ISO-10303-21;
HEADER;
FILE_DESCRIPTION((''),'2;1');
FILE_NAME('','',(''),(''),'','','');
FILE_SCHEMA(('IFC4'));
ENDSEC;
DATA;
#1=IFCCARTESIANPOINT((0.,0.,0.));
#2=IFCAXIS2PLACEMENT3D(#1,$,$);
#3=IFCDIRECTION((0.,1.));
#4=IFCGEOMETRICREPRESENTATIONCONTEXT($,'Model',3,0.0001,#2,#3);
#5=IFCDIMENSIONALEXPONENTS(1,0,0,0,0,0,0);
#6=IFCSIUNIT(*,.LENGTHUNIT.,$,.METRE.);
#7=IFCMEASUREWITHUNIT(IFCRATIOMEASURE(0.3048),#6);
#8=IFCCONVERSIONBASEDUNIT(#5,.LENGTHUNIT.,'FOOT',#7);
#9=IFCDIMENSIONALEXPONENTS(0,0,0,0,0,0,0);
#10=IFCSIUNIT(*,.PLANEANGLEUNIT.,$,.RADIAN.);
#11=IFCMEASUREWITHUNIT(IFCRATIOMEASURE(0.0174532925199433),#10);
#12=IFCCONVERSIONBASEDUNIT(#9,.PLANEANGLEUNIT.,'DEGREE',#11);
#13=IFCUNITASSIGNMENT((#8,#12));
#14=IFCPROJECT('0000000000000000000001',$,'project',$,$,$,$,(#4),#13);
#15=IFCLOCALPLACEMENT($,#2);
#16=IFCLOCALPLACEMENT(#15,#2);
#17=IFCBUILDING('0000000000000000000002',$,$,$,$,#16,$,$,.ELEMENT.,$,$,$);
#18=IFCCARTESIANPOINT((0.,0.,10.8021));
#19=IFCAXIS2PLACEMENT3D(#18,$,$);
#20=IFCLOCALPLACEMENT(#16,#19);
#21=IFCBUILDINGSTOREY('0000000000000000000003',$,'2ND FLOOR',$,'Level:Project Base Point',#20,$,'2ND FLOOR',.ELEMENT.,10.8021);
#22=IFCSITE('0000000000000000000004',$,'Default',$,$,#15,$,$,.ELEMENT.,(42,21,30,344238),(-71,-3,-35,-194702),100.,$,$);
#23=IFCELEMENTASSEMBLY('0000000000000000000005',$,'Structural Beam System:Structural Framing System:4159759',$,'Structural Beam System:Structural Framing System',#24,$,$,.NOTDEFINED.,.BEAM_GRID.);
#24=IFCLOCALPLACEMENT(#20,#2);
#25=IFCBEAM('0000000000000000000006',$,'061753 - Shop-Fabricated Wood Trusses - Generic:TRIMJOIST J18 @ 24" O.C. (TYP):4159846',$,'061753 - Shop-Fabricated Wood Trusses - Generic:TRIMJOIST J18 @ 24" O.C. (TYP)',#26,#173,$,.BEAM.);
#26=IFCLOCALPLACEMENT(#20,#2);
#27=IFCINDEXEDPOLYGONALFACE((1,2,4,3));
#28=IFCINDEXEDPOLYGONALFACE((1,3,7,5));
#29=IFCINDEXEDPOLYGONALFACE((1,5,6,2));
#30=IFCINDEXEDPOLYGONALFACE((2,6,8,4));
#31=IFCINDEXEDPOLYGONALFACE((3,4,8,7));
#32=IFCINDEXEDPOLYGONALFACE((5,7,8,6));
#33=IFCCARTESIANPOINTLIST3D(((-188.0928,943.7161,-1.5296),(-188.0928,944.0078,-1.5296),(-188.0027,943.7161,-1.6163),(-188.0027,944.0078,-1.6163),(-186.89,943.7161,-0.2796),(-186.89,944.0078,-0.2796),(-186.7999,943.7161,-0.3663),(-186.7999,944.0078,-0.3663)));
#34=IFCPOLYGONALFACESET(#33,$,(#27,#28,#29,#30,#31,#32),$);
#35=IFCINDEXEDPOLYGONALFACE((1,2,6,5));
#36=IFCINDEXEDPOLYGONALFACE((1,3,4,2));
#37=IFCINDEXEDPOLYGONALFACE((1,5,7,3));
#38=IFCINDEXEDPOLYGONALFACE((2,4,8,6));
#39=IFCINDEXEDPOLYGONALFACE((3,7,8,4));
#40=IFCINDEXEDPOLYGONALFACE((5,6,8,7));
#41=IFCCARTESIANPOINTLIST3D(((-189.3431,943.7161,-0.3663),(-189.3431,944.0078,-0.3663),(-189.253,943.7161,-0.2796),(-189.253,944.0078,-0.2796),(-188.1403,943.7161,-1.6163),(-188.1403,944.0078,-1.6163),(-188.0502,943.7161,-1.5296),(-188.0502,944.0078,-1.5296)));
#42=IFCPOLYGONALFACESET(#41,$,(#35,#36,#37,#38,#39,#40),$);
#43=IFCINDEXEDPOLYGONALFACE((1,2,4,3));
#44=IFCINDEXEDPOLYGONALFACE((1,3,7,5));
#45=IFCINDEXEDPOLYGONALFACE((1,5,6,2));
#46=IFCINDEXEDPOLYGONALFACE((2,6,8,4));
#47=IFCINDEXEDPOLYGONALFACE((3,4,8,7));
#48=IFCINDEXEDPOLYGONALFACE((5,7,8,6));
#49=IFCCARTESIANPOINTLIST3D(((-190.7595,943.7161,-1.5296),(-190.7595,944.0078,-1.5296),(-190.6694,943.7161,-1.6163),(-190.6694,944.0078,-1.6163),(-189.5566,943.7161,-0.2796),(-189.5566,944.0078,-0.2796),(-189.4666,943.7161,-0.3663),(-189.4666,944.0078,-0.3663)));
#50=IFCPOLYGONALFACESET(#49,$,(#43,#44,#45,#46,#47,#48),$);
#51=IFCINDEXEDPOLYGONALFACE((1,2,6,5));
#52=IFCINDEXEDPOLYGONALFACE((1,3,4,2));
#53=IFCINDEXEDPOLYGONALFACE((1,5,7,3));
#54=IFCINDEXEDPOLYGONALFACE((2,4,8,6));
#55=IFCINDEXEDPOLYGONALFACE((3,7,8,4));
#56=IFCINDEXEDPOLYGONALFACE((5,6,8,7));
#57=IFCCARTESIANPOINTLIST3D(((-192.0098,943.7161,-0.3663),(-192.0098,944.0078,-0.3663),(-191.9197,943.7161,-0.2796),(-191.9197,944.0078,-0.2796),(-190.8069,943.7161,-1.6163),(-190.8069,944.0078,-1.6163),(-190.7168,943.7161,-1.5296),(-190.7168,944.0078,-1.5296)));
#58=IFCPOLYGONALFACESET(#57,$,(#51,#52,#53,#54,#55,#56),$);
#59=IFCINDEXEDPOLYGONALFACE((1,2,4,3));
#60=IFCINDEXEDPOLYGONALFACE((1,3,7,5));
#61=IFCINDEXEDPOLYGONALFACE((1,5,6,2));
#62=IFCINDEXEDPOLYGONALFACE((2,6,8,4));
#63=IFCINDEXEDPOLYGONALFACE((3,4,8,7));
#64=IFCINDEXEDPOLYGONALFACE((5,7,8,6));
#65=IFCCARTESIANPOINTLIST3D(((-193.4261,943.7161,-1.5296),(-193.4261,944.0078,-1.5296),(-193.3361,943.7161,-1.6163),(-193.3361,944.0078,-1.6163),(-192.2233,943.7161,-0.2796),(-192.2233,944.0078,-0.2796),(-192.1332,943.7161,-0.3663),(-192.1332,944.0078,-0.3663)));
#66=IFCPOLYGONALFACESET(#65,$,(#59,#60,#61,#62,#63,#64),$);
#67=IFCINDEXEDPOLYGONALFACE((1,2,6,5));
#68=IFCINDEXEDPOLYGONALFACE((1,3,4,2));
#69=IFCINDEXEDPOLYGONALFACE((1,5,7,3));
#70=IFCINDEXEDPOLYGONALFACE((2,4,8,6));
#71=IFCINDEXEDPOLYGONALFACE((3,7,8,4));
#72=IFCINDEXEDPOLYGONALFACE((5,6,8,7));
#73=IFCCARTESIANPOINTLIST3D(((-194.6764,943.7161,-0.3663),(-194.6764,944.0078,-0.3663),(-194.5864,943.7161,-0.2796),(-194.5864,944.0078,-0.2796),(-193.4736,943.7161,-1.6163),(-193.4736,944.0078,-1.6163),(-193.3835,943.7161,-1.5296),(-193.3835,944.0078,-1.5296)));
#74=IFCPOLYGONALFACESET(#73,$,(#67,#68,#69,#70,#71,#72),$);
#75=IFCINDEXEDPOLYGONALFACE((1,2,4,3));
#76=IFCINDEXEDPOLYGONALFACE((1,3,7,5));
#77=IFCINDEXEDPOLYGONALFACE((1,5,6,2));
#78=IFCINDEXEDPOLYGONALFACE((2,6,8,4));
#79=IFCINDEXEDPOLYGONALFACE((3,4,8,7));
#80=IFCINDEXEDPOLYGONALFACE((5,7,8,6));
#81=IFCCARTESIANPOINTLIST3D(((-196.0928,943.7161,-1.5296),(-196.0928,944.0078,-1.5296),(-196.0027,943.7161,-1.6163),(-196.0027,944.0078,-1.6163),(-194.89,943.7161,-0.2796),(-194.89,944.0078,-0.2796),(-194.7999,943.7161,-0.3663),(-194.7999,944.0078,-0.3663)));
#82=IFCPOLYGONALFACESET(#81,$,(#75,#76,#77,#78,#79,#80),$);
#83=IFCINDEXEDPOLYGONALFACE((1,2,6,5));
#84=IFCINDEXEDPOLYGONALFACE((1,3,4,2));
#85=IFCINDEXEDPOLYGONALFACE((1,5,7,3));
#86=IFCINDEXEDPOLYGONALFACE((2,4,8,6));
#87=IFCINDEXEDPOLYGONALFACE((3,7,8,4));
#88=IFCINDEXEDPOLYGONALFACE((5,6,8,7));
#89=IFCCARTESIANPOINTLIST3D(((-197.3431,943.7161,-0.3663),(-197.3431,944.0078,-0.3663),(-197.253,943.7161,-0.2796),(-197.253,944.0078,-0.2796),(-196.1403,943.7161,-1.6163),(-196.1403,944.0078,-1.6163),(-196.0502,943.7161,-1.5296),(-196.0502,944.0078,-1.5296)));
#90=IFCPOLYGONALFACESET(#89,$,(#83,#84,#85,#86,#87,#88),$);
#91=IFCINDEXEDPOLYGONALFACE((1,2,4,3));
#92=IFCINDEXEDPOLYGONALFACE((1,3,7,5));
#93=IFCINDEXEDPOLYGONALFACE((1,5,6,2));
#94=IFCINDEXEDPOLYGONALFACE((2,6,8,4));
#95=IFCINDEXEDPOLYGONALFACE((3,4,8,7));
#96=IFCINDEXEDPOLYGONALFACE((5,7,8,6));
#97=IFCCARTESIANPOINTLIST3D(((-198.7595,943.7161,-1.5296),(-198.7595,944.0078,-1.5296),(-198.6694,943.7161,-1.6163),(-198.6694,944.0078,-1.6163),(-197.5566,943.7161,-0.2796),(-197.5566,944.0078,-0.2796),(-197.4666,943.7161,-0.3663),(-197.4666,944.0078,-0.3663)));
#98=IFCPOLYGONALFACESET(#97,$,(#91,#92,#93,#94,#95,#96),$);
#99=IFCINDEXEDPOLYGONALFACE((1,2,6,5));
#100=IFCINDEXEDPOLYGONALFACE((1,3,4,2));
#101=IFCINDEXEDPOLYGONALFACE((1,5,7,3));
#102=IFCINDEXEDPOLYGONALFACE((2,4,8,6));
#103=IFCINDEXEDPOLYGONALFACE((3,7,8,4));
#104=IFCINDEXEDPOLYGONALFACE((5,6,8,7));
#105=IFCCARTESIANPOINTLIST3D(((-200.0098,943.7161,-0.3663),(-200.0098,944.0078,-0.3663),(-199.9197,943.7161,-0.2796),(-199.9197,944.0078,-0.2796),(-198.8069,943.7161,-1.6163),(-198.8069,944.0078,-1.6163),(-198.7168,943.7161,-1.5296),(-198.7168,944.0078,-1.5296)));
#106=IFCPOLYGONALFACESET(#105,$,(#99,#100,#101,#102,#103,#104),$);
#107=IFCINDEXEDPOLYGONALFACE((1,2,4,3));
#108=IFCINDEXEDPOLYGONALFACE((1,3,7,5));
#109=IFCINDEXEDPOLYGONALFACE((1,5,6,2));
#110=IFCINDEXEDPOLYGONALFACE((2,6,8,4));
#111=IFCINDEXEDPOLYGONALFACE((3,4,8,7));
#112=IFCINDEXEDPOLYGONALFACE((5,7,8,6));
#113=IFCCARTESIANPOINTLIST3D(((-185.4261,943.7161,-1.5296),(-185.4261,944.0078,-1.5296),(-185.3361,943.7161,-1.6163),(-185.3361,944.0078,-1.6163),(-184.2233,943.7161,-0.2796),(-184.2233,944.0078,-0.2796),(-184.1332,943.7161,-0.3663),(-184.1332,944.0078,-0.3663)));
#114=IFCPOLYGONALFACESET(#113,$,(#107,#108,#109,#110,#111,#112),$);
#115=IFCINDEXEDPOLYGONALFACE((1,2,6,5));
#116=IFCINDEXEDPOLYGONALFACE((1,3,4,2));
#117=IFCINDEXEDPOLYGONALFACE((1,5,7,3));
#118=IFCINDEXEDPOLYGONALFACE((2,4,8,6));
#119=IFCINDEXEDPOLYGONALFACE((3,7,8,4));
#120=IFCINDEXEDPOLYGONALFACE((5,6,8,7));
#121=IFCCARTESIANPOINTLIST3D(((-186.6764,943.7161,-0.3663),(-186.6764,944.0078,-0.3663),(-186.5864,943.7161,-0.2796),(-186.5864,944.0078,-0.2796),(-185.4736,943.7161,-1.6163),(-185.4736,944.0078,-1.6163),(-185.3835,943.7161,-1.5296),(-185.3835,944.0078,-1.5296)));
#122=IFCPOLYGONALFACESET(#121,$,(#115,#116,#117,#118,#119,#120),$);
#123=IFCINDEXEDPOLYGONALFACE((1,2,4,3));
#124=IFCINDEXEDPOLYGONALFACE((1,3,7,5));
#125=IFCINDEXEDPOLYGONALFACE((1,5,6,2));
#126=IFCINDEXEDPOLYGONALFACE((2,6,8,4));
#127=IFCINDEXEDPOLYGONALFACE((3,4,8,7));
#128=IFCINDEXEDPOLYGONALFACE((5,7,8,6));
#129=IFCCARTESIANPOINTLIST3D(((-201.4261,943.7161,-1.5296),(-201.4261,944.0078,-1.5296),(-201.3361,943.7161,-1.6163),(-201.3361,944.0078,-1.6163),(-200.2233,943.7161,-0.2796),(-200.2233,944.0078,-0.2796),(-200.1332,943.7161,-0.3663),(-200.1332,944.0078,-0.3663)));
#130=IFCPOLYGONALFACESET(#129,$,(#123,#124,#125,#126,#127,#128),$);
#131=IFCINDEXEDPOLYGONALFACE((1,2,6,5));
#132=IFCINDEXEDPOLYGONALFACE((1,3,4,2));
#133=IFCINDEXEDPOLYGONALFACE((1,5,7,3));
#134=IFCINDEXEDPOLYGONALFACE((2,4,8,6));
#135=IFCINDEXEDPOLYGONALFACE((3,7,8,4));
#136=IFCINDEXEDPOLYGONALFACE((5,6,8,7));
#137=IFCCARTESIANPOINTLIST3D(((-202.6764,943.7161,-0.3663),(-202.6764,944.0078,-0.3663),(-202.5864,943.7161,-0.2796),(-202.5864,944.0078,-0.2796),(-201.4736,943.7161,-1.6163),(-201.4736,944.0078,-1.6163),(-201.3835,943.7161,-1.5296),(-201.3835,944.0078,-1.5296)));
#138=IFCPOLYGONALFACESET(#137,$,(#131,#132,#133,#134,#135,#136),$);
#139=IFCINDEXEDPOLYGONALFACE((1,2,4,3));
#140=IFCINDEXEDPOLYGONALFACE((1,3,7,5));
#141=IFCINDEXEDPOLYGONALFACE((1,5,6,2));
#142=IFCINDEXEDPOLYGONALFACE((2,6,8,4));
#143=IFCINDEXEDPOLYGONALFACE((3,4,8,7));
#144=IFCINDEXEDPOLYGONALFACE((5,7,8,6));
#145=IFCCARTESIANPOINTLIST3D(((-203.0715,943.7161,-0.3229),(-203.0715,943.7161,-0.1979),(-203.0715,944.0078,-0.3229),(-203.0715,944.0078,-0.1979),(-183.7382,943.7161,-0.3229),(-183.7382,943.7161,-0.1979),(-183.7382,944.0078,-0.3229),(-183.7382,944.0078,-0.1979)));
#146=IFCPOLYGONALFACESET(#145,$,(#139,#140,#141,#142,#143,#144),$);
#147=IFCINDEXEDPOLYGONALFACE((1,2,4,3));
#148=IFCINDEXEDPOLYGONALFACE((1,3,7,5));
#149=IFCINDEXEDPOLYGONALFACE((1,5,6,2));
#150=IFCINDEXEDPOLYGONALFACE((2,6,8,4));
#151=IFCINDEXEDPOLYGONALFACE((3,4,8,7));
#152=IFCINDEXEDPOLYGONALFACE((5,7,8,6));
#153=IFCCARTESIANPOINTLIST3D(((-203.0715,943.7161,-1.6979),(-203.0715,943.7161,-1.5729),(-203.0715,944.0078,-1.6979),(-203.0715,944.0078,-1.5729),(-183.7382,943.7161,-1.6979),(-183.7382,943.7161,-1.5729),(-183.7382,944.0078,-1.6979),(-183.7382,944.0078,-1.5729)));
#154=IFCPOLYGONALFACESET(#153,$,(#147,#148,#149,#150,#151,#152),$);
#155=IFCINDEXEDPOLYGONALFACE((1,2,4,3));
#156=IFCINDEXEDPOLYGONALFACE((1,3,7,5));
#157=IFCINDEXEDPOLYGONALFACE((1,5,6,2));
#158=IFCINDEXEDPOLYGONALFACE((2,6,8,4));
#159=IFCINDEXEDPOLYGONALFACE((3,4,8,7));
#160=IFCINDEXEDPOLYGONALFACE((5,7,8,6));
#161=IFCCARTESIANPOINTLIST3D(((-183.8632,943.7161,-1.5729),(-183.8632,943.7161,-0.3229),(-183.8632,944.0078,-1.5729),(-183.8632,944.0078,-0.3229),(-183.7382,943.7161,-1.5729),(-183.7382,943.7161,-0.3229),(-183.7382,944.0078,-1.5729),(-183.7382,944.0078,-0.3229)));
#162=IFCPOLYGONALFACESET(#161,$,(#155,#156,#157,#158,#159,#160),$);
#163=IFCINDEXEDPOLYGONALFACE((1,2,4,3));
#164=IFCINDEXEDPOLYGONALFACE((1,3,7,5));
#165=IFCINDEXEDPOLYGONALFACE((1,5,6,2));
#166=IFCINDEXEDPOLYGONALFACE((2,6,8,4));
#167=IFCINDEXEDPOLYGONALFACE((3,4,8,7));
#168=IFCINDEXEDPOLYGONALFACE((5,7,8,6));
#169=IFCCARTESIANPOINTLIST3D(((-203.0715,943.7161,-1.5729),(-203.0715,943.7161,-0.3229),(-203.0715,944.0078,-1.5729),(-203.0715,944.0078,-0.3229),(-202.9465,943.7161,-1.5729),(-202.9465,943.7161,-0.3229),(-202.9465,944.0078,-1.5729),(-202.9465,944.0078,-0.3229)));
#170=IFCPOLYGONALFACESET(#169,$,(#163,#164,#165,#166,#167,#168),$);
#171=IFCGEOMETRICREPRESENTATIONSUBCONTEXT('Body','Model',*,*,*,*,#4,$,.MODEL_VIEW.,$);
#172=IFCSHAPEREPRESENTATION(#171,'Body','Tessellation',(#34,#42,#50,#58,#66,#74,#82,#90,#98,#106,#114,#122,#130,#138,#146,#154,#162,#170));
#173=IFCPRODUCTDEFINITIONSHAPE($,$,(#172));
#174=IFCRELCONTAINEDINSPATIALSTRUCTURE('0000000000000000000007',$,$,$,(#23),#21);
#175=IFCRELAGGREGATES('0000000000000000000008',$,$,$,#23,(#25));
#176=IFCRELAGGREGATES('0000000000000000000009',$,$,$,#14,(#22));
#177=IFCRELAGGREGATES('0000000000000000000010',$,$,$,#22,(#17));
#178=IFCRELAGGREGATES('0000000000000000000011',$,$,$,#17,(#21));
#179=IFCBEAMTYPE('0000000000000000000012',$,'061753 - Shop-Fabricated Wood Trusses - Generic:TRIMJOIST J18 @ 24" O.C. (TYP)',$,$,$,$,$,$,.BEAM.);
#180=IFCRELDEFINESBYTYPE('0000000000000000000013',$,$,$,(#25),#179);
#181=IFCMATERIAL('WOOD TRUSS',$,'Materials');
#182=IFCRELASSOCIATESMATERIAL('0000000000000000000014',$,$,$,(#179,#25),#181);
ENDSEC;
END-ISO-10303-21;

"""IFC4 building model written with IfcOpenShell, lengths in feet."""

from ifc_helpers import new_model, entity, si_unit, converted_unit, direction, frame, frame_2d, origin, origin_2d_with_axis, place, context, subcontext, project, spatial, rectangle, extrude, source, transform, mapped, material, material_profile, profile_set, profile_usage, type_object, type_shapes, element, aggregate, save


model = new_model("IFC4")

# Units and contexts
model_context = context("Model", 3, precision=0.0001, world=origin(), true_north=direction((0.0, 1.0)))
body_context = subcontext(model_context, "Body", "Model", "MODEL_VIEW")
ifc_project = project(units=[converted_unit("LENGTHUNIT", "FOOT", entity("IfcRatioMeasure", 0.3048), si_unit("LENGTHUNIT", "METRE"), dimensions=[1, 0, 0, 0, 0, 0, 0]), converted_unit("PLANEANGLEUNIT", "DEGREE", entity("IfcRatioMeasure", 0.0174532925199433), si_unit("PLANEANGLEUNIT", "RADIAN"), dimensions=[0, 0, 0, 0, 0, 0, 0])], contexts=[model_context])

# Site, building, storey
site_placement = place(None, origin())
site = spatial("IfcSite", under=ifc_project, at=site_placement, Name="Default", CompositionType="ELEMENT", RefLatitude=(42, 21, 30, 344238), RefLongitude=(-71, -3, -35, -194702), RefElevation=100.0)
building_placement = place(site_placement, origin())
building = spatial("IfcBuilding", under=site, at=building_placement, CompositionType="ELEMENT")
storey_placement = place(building_placement, frame((0.0, 0.0, 10.8021)))
storey = spatial("IfcBuildingStorey", under=building, at=storey_placement, Name="2ND FLOOR", ObjectType="Level:Project Base Point", LongName="2ND FLOOR", CompositionType="ELEMENT", Elevation=10.8021)

# Element assembly, beam
ifc_material_1 = material(Name="WOOD TRUSS", Category="Materials")
ifc_material_profile_1 = material_profile(ifc_material_1, rectangle(XDim=1.7347, YDim=0.125, at=frame_2d((0.0, 0.0), x_axis=(1.0, 0.0))), Name="TRIMJOIST J18 @ 24\" O.C. (TYP)")
ifc_material_profile_2 = material_profile(ifc_material_1, rectangle(XDim=1.7347, YDim=0.125, at=frame_2d((0.0, 0.0), x_axis=(1.0, 0.0))), Name="TRIMJOIST J18 @ 24\" O.C. (TYP)")
ifc_material_profile_3 = material_profile(ifc_material_1, rectangle(XDim=1.7347, YDim=0.125, at=frame_2d((0.0, 0.0), x_axis=(1.0, 0.0))), Name="TRIMJOIST J18 @ 24\" O.C. (TYP)")
ifc_material_profile_4 = material_profile(ifc_material_1, rectangle(XDim=1.7347, YDim=0.125, at=frame_2d((0.0, 0.0), x_axis=(1.0, 0.0))), Name="TRIMJOIST J18 @ 24\" O.C. (TYP)")
ifc_material_profile_5 = material_profile(ifc_material_1, rectangle(XDim=1.7347, YDim=0.125, at=frame_2d((0.0, 0.0), x_axis=(1.0, 0.0))), Name="TRIMJOIST J18 @ 24\" O.C. (TYP)")
ifc_material_profile_6 = material_profile(ifc_material_1, rectangle(XDim=1.7347, YDim=0.125, at=frame_2d((0.0, 0.0), x_axis=(1.0, 0.0))), Name="TRIMJOIST J18 @ 24\" O.C. (TYP)")
ifc_material_profile_7 = material_profile(ifc_material_1, rectangle(XDim=1.7347, YDim=0.125, at=frame_2d((0.0, 0.0), x_axis=(1.0, 0.0))), Name="TRIMJOIST J18 @ 24\" O.C. (TYP)")
ifc_material_profile_8 = material_profile(ifc_material_1, rectangle(XDim=1.7347, YDim=0.125, at=frame_2d((0.0, 0.0), x_axis=(1.0, 0.0))), Name="TRIMJOIST J18 @ 24\" O.C. (TYP)")
ifc_material_profile_9 = material_profile(ifc_material_1, rectangle(XDim=1.7347, YDim=0.125, at=frame_2d((0.0, 0.0), x_axis=(1.0, 0.0))), Name="TRIMJOIST J18 @ 24\" O.C. (TYP)")
ifc_material_profile_10 = material_profile(ifc_material_1, rectangle(XDim=1.7347, YDim=0.125, at=origin_2d_with_axis()), Name="TRIMJOIST J18 @ 24\" O.C. (TYP)")
ifc_material_profile_11 = material_profile(ifc_material_1, rectangle(XDim=0.125, YDim=0.2917, at=origin_2d_with_axis()), Name="TRIMJOIST J18 @ 24\" O.C. (TYP)")
ifc_material_profile_12 = material_profile(ifc_material_1, rectangle(XDim=0.125, YDim=0.2917, at=origin_2d_with_axis()), Name="TRIMJOIST J18 @ 24\" O.C. (TYP)")
ifc_material_profile_13 = material_profile(ifc_material_1, rectangle(XDim=1.25, YDim=0.2917, at=origin_2d_with_axis()), Name="TRIMJOIST J18 @ 24\" O.C. (TYP)")
ifc_material_profile_14 = material_profile(ifc_material_1, rectangle(XDim=1.25, YDim=0.2917, at=origin_2d_with_axis()), Name="TRIMJOIST J18 @ 24\" O.C. (TYP)")
ifc_profile_set_1 = profile_set([ifc_material_profile_1, ifc_material_profile_2, ifc_material_profile_3, ifc_material_profile_4, ifc_material_profile_5, ifc_material_profile_6, ifc_material_profile_7, ifc_material_profile_8, ifc_material_profile_9, ifc_material_profile_10, ifc_material_profile_11, ifc_material_profile_12, ifc_material_profile_13, ifc_material_profile_14], Name="TRIMJOIST J18 @ 24\" O.C. (TYP)")
beam_type_1 = type_object("IfcBeamType", Name="061753 - Shop-Fabricated Wood Trusses - Generic:TRIMJOIST J18 @ 24\" O.C. (TYP)", PredefinedType="BEAM", material=ifc_profile_set_1)
shared_shape_1 = source(origin(), body_context, "Body", "SweptSolid", [
    extrude(rectangle(XDim=1.7347, YDim=0.125, at=frame_2d((0.0, 0.0), x_axis=(1.0, 0.0))), frame((5.9585, -0.1458, 0.0), z_axis=(0.0, 1.0, 0.0), x_axis=(0.693383, 0.0, 0.720569)), (0.0, 0.0, 1.0), 0.2917),
    extrude(rectangle(XDim=1.7347, YDim=0.125, at=origin_2d_with_axis()), frame((4.7082, -0.1458, 0.0), z_axis=(0.0, 1.0, 0.0), x_axis=(0.693383, 0.0, -0.720569)), (0.0, 0.0, 1.0), 0.2917),
    extrude(rectangle(XDim=1.7347, YDim=0.125, at=frame_2d((0.0, 0.0), x_axis=(1.0, 0.0))), frame((3.2918, -0.1458, 0.0), z_axis=(0.0, 1.0, 0.0), x_axis=(0.693383, 0.0, 0.720569)), (0.0, 0.0, 1.0), 0.2917),
    extrude(rectangle(XDim=1.7347, YDim=0.125, at=frame_2d((0.0, 0.0), x_axis=(1.0, 0.0))), frame((2.0415, -0.1458, 0.0), z_axis=(0.0, 1.0, 0.0), x_axis=(0.693383, 0.0, -0.720569)), (0.0, 0.0, 1.0), 0.2917),
    extrude(rectangle(XDim=1.7347, YDim=0.125, at=frame_2d((0.0, 0.0), x_axis=(1.0, 0.0))), frame((0.6251, -0.1458, 0.0), z_axis=(0.0, 1.0, 0.0), x_axis=(0.693383, 0.0, 0.720569)), (0.0, 0.0, 1.0), 0.2917),
    extrude(rectangle(XDim=1.7347, YDim=0.125, at=frame_2d((0.0, 0.0), x_axis=(1.0, 0.0))), frame((-0.6251, -0.1458, 0.0), z_axis=(0.0, 1.0, 0.0), x_axis=(0.693383, 0.0, -0.720569)), (0.0, 0.0, 1.0), 0.2917),
    extrude(rectangle(XDim=1.7347, YDim=0.125, at=frame_2d((0.0, 0.0), x_axis=(1.0, 0.0))), frame((-2.0415, -0.1458, 0.0), z_axis=(0.0, 1.0, 0.0), x_axis=(0.693383, 0.0, 0.720569)), (0.0, 0.0, 1.0), 0.2917),
    extrude(rectangle(XDim=1.7347, YDim=0.125, at=origin_2d_with_axis()), frame((-3.2918, -0.1458, 0.0), z_axis=(0.0, 1.0, 0.0), x_axis=(0.693383, 0.0, -0.720569)), (0.0, 0.0, 1.0), 0.2917),
    extrude(rectangle(XDim=1.7347, YDim=0.125, at=frame_2d((0.0, 0.0), x_axis=(1.0, 0.0))), frame((-4.7082, -0.1458, 0.0), z_axis=(0.0, 1.0, 0.0), x_axis=(0.693383, 0.0, 0.720569)), (0.0, 0.0, 1.0), 0.2917),
    extrude(rectangle(XDim=1.7347, YDim=0.125, at=frame_2d((0.0, 0.0), x_axis=(1.0, 0.0))), frame((-5.9585, -0.1458, 0.0), z_axis=(0.0, 1.0, 0.0), x_axis=(0.693383, 0.0, -0.720569)), (0.0, 0.0, 1.0), 0.2917),
    extrude(rectangle(XDim=1.7347, YDim=0.125, at=frame_2d((0.0, 0.0), x_axis=(1.0, 0.0))), frame((8.6251, -0.1458, 0.0), z_axis=(0.0, 1.0, 0.0), x_axis=(0.693383, 0.0, 0.720569)), (0.0, 0.0, 1.0), 0.2917),
    extrude(rectangle(XDim=1.7347, YDim=0.125, at=origin_2d_with_axis()), frame((7.3749, -0.1458, 0.0), z_axis=(0.0, 1.0, 0.0), x_axis=(0.693383, 0.0, -0.720569)), (0.0, 0.0, 1.0), 0.2917),
    extrude(rectangle(XDim=1.7347, YDim=0.125, at=frame_2d((0.0, 0.0), x_axis=(1.0, 0.0))), frame((-7.3749, -0.1458, 0.0), z_axis=(0.0, 1.0, 0.0), x_axis=(0.693383, 0.0, 0.720569)), (0.0, 0.0, 1.0), 0.2917),
    extrude(rectangle(XDim=1.7347, YDim=0.125, at=origin_2d_with_axis()), frame((-8.6251, -0.1458, 0.0), z_axis=(0.0, 1.0, 0.0), x_axis=(0.693383, 0.0, -0.720569)), (0.0, 0.0, 1.0), 0.2917),
    extrude(rectangle(XDim=0.125, YDim=0.2917, at=origin_2d_with_axis()), frame((-9.6667, 0.0, 0.6875), z_axis=(1.0, 0.0, 0.0), x_axis=(0.0, 0.0, -1.0)), (0.0, 0.0, 1.0), 19.3333),
    extrude(rectangle(XDim=0.125, YDim=0.2917, at=origin_2d_with_axis()), frame((-9.6667, 0.0, -0.6875), z_axis=(1.0, 0.0, 0.0), x_axis=(0.0, 0.0, -1.0)), (0.0, 0.0, 1.0), 19.3333),
    extrude(rectangle(XDim=1.25, YDim=0.2917, at=origin_2d_with_axis()), frame((9.5417, 0.0, 0.0), z_axis=(1.0, 0.0, 0.0), x_axis=(0.0, 0.0, -1.0)), (0.0, 0.0, 1.0), 0.125),
    extrude(rectangle(XDim=1.25, YDim=0.2917, at=origin_2d_with_axis()), frame((-9.6667, 0.0, 0.0), z_axis=(1.0, 0.0, 0.0), x_axis=(0.0, 0.0, -1.0)), (0.0, 0.0, 1.0), 0.125),
])
type_shapes(beam_type_1, [shared_shape_1])
assembly_1_placement = place(storey_placement, origin())
assembly_1 = element("IfcElementAssembly", 1, at=assembly_1_placement, inside=storey, Name="Structural Beam System:Structural Framing System:4159759", ObjectType="Structural Beam System:Structural Framing System", AssemblyPlace="NOTDEFINED", PredefinedType="BEAM_GRID")
ifc_profile_usage_1 = profile_usage(ifc_profile_set_1, cardinal=8)
beam_1_placement = place(assembly_1_placement, frame((-193.4048, 943.8619, -0.9479)))
beam_1 = element("IfcBeam", 2, at=beam_1_placement, type_object=beam_type_1, material=ifc_profile_usage_1, Name="061753 - Shop-Fabricated Wood Trusses - Generic:TRIMJOIST J18 @ 24\" O.C. (TYP):4159846", ObjectType="061753 - Shop-Fabricated Wood Trusses - Generic:TRIMJOIST J18 @ 24\" O.C. (TYP)", PredefinedType="BEAM", context=body_context, shape_type="MappedRepresentation", body=[
    mapped(shared_shape_1, transform((0.0, 0.0, 0.0), scale=1.0)),
])

aggregate(assembly_1, [beam_1])

save(model, "model.ifc")
